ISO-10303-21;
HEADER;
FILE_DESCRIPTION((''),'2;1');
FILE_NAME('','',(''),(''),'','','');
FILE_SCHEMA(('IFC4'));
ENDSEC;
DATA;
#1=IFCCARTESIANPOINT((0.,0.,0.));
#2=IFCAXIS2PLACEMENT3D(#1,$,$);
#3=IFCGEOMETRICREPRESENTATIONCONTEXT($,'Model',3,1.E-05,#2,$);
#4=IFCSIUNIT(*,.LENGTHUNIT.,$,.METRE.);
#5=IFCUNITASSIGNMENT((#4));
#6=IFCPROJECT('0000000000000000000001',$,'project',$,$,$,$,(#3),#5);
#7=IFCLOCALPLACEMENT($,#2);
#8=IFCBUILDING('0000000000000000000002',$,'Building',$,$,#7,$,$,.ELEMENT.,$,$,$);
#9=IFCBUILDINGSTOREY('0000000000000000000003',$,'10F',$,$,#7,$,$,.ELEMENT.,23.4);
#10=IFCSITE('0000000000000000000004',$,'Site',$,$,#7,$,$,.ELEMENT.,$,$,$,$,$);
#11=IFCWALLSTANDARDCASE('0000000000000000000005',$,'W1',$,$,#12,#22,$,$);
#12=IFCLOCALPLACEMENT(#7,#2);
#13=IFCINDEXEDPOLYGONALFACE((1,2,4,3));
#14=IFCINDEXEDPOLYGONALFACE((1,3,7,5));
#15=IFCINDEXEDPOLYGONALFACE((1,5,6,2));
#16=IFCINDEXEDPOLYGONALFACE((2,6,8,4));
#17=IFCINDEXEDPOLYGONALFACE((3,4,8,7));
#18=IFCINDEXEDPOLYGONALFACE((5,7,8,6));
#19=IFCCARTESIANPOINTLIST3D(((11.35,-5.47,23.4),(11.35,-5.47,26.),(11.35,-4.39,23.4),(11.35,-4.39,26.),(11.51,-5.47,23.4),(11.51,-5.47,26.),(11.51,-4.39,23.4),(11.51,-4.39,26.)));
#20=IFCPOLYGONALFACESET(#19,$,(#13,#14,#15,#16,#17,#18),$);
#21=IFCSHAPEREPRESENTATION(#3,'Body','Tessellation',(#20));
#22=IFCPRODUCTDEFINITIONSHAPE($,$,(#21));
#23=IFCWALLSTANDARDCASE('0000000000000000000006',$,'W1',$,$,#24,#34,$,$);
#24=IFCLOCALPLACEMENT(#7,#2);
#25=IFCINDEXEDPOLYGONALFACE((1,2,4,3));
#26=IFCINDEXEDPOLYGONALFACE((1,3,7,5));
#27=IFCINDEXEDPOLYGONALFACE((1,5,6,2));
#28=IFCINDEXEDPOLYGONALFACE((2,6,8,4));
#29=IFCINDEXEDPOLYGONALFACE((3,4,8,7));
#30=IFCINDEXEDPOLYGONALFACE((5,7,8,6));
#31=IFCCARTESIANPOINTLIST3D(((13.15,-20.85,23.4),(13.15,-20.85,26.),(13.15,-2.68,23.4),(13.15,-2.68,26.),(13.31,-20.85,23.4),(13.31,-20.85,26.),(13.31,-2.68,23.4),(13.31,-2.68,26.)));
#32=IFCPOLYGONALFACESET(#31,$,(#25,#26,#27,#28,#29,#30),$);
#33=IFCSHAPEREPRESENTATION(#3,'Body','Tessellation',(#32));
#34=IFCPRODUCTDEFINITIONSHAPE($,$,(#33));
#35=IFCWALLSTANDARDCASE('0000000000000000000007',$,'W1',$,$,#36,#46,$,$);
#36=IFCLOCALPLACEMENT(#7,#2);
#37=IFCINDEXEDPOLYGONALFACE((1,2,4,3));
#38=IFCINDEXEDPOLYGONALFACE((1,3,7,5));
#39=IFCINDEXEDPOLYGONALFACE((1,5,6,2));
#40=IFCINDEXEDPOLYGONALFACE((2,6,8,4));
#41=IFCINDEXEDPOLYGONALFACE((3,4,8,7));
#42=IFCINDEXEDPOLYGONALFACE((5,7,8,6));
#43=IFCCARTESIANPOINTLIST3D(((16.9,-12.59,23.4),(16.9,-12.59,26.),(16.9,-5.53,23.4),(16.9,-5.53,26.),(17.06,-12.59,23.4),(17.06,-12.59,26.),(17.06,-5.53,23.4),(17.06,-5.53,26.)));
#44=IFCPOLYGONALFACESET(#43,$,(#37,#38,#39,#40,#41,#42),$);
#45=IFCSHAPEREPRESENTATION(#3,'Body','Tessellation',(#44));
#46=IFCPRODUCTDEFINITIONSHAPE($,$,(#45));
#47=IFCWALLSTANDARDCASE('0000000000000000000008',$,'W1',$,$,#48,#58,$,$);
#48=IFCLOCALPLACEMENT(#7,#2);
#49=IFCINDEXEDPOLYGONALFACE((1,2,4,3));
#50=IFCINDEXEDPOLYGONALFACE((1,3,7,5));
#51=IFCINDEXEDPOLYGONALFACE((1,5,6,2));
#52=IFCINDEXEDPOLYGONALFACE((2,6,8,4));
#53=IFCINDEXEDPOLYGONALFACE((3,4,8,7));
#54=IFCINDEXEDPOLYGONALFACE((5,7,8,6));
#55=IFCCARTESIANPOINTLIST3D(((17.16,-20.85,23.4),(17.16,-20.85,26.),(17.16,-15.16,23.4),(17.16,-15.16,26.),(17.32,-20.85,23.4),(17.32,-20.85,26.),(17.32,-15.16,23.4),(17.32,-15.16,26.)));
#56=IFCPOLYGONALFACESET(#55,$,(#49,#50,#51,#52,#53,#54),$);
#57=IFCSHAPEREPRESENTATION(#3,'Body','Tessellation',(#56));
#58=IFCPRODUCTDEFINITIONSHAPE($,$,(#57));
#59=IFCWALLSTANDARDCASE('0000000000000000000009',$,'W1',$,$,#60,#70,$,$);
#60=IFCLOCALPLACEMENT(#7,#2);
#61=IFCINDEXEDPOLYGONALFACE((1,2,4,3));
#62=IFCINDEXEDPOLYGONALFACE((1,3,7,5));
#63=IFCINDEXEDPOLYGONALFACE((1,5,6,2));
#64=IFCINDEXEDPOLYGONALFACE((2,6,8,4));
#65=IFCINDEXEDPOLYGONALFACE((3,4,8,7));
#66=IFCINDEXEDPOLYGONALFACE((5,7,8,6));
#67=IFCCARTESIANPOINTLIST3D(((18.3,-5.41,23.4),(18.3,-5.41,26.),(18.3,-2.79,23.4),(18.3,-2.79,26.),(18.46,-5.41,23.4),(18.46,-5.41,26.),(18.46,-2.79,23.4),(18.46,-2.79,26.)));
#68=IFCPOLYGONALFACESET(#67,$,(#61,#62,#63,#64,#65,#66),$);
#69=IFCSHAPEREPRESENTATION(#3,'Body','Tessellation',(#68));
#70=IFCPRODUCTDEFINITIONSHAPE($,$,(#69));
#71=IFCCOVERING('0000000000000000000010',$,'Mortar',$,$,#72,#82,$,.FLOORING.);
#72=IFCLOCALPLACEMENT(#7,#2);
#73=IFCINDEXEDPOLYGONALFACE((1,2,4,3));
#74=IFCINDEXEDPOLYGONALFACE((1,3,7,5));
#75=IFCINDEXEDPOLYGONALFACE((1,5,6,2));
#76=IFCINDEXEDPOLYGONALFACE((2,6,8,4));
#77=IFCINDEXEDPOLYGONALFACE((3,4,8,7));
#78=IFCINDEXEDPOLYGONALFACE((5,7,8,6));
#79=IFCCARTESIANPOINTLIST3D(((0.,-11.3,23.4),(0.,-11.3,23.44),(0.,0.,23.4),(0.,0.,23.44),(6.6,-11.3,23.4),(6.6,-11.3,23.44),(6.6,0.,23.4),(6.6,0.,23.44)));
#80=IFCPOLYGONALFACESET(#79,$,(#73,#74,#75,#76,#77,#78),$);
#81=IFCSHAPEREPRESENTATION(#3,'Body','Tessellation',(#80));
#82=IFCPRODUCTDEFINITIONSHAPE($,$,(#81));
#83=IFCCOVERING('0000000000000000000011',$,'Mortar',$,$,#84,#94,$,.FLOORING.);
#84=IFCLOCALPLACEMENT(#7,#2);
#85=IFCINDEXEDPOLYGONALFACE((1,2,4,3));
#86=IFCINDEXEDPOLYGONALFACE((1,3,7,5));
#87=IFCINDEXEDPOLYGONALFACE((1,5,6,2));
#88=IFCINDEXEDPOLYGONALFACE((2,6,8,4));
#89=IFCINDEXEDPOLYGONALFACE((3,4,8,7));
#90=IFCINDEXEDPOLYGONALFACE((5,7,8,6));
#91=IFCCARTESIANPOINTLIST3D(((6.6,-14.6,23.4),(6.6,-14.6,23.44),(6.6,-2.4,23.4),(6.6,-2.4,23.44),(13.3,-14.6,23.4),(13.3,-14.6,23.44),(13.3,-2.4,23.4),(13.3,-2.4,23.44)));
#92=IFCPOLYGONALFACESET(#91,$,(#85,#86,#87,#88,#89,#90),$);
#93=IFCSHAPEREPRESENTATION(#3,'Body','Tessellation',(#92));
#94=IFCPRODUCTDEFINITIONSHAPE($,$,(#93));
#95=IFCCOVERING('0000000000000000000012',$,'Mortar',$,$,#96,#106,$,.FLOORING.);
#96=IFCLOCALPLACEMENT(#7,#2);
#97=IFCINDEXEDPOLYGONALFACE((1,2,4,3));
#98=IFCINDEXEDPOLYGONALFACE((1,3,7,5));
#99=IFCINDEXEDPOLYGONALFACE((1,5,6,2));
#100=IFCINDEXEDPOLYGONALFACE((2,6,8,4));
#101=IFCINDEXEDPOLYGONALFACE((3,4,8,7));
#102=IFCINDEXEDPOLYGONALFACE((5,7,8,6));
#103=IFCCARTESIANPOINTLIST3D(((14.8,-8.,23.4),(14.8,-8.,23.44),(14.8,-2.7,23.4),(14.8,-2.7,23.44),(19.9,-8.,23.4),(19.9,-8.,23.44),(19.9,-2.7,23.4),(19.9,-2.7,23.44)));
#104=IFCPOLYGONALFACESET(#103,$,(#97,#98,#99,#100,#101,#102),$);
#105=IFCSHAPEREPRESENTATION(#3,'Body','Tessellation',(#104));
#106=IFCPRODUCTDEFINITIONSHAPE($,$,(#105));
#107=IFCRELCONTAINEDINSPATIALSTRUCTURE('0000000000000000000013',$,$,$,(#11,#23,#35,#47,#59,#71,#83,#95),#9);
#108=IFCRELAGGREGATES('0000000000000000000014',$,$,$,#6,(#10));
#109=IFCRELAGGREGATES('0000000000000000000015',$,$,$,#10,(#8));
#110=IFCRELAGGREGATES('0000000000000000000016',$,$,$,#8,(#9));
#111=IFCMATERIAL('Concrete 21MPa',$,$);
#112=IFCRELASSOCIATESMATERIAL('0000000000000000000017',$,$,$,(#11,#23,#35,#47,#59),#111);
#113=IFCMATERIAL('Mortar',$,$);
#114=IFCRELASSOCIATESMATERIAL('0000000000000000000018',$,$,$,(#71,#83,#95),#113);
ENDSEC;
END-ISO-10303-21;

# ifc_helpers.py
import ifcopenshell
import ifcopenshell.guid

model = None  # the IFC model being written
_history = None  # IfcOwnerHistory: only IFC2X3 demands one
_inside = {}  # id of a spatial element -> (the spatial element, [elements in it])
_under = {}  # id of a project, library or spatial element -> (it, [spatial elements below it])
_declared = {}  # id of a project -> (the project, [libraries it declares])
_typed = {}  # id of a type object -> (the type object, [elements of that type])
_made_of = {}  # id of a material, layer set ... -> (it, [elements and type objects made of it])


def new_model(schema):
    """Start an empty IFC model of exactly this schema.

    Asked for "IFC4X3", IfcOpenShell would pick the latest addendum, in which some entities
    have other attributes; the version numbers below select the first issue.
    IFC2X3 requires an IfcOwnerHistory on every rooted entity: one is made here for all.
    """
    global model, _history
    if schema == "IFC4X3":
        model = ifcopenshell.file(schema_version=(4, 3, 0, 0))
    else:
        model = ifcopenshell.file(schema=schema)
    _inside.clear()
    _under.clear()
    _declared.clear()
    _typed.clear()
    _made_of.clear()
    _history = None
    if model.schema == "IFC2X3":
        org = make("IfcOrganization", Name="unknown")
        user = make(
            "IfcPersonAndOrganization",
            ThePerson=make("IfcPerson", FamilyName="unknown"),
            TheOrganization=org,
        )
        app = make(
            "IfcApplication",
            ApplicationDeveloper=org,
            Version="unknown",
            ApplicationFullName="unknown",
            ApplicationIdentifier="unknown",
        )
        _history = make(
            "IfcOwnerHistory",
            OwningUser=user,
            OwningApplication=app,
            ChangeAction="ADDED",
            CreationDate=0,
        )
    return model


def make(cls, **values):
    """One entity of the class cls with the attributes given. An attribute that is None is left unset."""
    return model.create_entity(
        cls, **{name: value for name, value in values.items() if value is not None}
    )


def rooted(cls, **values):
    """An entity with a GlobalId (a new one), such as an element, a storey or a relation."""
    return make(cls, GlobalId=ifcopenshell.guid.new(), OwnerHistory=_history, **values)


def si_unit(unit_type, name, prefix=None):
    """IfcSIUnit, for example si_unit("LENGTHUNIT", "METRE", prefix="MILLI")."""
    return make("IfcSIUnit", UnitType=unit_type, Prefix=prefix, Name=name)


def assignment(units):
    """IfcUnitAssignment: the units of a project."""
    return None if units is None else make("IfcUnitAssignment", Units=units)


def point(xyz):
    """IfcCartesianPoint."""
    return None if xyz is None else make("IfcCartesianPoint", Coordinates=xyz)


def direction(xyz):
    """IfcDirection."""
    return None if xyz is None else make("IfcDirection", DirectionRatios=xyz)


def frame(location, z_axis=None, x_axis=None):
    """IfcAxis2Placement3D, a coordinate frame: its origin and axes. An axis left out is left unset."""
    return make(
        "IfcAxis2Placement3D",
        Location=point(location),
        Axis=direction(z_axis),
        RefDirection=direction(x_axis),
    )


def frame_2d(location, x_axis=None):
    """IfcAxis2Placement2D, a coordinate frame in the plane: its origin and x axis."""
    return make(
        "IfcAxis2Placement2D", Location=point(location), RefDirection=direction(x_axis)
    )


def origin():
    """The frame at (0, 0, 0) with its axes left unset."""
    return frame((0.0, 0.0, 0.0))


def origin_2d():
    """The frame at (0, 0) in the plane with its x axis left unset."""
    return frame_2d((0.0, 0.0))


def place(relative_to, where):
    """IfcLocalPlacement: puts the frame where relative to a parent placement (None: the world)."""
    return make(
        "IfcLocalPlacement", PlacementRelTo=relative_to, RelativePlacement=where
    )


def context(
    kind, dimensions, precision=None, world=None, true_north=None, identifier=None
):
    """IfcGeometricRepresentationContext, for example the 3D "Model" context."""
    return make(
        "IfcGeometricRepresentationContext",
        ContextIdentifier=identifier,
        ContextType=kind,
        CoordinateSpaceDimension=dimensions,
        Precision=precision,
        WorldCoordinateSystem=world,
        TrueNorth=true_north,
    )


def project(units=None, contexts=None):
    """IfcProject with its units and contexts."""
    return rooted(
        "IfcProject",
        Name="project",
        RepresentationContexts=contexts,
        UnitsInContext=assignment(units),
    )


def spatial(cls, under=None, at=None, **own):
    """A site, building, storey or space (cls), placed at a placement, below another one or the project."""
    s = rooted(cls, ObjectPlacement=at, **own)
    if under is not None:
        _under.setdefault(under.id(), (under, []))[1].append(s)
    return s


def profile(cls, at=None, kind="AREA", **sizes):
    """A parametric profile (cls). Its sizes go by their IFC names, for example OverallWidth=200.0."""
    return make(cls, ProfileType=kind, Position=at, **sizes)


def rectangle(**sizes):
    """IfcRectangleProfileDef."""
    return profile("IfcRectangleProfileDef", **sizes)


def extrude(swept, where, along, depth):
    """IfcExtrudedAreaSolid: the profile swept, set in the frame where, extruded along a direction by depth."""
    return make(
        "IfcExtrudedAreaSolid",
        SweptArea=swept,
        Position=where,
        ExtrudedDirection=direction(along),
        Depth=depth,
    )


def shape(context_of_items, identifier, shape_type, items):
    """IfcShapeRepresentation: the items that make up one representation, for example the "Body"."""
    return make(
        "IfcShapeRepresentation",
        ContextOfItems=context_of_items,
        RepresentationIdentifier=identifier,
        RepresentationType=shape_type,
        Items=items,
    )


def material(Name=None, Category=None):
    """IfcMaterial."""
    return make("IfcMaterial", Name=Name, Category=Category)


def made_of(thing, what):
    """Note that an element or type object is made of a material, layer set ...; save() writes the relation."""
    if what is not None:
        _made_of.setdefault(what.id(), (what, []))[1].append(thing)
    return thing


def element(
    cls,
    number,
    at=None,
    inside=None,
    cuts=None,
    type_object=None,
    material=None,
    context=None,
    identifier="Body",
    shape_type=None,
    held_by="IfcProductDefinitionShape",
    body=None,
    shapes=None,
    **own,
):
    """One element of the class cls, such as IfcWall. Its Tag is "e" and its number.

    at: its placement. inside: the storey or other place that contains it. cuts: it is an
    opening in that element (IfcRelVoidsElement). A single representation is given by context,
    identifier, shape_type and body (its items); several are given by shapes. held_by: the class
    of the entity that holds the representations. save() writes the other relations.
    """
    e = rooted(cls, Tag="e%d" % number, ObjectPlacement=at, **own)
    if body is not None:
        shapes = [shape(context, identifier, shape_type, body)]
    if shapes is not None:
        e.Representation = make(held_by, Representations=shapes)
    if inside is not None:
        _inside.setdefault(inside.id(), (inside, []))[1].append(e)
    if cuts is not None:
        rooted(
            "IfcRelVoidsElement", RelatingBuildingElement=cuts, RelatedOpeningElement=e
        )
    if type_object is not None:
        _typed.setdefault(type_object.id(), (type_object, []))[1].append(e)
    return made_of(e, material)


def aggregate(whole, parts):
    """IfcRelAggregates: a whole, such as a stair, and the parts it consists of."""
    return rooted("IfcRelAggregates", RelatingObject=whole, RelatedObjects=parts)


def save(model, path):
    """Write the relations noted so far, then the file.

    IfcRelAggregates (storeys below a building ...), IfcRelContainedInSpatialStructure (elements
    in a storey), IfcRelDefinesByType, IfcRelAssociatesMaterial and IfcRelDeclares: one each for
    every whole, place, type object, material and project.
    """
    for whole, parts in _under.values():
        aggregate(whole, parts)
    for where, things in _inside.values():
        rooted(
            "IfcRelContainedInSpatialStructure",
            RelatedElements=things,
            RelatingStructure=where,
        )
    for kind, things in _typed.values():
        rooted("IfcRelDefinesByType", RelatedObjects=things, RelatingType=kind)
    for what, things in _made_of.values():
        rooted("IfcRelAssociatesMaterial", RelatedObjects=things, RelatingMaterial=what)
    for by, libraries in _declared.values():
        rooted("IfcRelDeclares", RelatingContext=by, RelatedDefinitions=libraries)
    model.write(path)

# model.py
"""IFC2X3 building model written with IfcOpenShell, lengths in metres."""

from ifc_helpers import new_model, si_unit, frame, origin, origin_2d, place, context, project, spatial, rectangle, extrude, material, element, save


model = new_model("IFC2X3")

# Units and contexts
model_context = context("Model", 3, precision=1e-05, world=origin())
ifc_project = project(units=[si_unit("LENGTHUNIT", "METRE")], contexts=[model_context])

# Site, building, storey
placement = place(None, origin())
site = spatial("IfcSite", under=ifc_project, at=placement, Name="Site", CompositionType="ELEMENT")
building = spatial("IfcBuilding", under=site, at=placement, Name="Building", CompositionType="ELEMENT")
storey = spatial("IfcBuildingStorey", under=building, at=placement, Name="10F", CompositionType="ELEMENT", Elevation=23.4)

# Shared definitions
ifc_material_1 = material(Name="Concrete 21MPa")

# Walls
wall_1_placement = place(None, frame((11.43, -4.93, 23.4)))
element("IfcWallStandardCase", 1, at=wall_1_placement, inside=storey, material=ifc_material_1, Name="W1", context=model_context, shape_type="SweptSolid", body=[
    extrude(rectangle(XDim=0.16, YDim=1.08, at=origin_2d()), origin(), (0.0, 0.0, 1.0), 2.6),
])
wall_2_placement = place(None, frame((13.23, -11.765, 23.4)))
element("IfcWallStandardCase", 2, at=wall_2_placement, inside=storey, material=ifc_material_1, Name="W1", context=model_context, shape_type="SweptSolid", body=[
    extrude(rectangle(XDim=0.16, YDim=18.17, at=origin_2d()), origin(), (0.0, 0.0, 1.0), 2.6),
])
wall_3_placement = place(None, frame((16.98, -9.06, 23.4)))
element("IfcWallStandardCase", 3, at=wall_3_placement, inside=storey, material=ifc_material_1, Name="W1", context=model_context, shape_type="SweptSolid", body=[
    extrude(rectangle(XDim=0.16, YDim=7.06, at=origin_2d()), origin(), (0.0, 0.0, 1.0), 2.6),
])
wall_4_placement = place(None, frame((17.24, -18.005, 23.4)))
element("IfcWallStandardCase", 4, at=wall_4_placement, inside=storey, material=ifc_material_1, Name="W1", context=model_context, shape_type="SweptSolid", body=[
    extrude(rectangle(XDim=0.16, YDim=5.69, at=origin_2d()), origin(), (0.0, 0.0, 1.0), 2.6),
])
wall_5_placement = place(None, frame((18.38, -4.1, 23.4)))
element("IfcWallStandardCase", 5, at=wall_5_placement, inside=storey, material=ifc_material_1, Name="W1", context=model_context, shape_type="SweptSolid", body=[
    extrude(rectangle(XDim=0.16, YDim=2.62, at=origin_2d()), origin(), (0.0, 0.0, 1.0), 2.6),
])

# Coverings
ifc_material_2 = material(Name="Mortar")
covering_1_placement = place(None, frame((3.3, -5.65, 23.4)))
element("IfcCovering", 6, at=covering_1_placement, inside=storey, material=ifc_material_2, Name="Mortar", PredefinedType="FLOORING", context=model_context, shape_type="SweptSolid", body=[
    extrude(rectangle(XDim=6.6, YDim=11.3, at=origin_2d()), origin(), (0.0, 0.0, 1.0), 0.04),
])
covering_2_placement = place(None, frame((9.95, -8.5, 23.4)))
element("IfcCovering", 7, at=covering_2_placement, inside=storey, material=ifc_material_2, Name="Mortar", PredefinedType="FLOORING", context=model_context, shape_type="SweptSolid", body=[
    extrude(rectangle(XDim=6.7, YDim=12.2, at=origin_2d()), origin(), (0.0, 0.0, 1.0), 0.04),
])
covering_3_placement = place(None, frame((17.35, -5.35, 23.4)))
element("IfcCovering", 8, at=covering_3_placement, inside=storey, material=ifc_material_2, Name="Mortar", PredefinedType="FLOORING", context=model_context, shape_type="SweptSolid", body=[
    extrude(rectangle(XDim=5.1, YDim=5.3, at=origin_2d()), origin(), (0.0, 0.0, 1.0), 0.04),
])

save(model, "model.ifc")
